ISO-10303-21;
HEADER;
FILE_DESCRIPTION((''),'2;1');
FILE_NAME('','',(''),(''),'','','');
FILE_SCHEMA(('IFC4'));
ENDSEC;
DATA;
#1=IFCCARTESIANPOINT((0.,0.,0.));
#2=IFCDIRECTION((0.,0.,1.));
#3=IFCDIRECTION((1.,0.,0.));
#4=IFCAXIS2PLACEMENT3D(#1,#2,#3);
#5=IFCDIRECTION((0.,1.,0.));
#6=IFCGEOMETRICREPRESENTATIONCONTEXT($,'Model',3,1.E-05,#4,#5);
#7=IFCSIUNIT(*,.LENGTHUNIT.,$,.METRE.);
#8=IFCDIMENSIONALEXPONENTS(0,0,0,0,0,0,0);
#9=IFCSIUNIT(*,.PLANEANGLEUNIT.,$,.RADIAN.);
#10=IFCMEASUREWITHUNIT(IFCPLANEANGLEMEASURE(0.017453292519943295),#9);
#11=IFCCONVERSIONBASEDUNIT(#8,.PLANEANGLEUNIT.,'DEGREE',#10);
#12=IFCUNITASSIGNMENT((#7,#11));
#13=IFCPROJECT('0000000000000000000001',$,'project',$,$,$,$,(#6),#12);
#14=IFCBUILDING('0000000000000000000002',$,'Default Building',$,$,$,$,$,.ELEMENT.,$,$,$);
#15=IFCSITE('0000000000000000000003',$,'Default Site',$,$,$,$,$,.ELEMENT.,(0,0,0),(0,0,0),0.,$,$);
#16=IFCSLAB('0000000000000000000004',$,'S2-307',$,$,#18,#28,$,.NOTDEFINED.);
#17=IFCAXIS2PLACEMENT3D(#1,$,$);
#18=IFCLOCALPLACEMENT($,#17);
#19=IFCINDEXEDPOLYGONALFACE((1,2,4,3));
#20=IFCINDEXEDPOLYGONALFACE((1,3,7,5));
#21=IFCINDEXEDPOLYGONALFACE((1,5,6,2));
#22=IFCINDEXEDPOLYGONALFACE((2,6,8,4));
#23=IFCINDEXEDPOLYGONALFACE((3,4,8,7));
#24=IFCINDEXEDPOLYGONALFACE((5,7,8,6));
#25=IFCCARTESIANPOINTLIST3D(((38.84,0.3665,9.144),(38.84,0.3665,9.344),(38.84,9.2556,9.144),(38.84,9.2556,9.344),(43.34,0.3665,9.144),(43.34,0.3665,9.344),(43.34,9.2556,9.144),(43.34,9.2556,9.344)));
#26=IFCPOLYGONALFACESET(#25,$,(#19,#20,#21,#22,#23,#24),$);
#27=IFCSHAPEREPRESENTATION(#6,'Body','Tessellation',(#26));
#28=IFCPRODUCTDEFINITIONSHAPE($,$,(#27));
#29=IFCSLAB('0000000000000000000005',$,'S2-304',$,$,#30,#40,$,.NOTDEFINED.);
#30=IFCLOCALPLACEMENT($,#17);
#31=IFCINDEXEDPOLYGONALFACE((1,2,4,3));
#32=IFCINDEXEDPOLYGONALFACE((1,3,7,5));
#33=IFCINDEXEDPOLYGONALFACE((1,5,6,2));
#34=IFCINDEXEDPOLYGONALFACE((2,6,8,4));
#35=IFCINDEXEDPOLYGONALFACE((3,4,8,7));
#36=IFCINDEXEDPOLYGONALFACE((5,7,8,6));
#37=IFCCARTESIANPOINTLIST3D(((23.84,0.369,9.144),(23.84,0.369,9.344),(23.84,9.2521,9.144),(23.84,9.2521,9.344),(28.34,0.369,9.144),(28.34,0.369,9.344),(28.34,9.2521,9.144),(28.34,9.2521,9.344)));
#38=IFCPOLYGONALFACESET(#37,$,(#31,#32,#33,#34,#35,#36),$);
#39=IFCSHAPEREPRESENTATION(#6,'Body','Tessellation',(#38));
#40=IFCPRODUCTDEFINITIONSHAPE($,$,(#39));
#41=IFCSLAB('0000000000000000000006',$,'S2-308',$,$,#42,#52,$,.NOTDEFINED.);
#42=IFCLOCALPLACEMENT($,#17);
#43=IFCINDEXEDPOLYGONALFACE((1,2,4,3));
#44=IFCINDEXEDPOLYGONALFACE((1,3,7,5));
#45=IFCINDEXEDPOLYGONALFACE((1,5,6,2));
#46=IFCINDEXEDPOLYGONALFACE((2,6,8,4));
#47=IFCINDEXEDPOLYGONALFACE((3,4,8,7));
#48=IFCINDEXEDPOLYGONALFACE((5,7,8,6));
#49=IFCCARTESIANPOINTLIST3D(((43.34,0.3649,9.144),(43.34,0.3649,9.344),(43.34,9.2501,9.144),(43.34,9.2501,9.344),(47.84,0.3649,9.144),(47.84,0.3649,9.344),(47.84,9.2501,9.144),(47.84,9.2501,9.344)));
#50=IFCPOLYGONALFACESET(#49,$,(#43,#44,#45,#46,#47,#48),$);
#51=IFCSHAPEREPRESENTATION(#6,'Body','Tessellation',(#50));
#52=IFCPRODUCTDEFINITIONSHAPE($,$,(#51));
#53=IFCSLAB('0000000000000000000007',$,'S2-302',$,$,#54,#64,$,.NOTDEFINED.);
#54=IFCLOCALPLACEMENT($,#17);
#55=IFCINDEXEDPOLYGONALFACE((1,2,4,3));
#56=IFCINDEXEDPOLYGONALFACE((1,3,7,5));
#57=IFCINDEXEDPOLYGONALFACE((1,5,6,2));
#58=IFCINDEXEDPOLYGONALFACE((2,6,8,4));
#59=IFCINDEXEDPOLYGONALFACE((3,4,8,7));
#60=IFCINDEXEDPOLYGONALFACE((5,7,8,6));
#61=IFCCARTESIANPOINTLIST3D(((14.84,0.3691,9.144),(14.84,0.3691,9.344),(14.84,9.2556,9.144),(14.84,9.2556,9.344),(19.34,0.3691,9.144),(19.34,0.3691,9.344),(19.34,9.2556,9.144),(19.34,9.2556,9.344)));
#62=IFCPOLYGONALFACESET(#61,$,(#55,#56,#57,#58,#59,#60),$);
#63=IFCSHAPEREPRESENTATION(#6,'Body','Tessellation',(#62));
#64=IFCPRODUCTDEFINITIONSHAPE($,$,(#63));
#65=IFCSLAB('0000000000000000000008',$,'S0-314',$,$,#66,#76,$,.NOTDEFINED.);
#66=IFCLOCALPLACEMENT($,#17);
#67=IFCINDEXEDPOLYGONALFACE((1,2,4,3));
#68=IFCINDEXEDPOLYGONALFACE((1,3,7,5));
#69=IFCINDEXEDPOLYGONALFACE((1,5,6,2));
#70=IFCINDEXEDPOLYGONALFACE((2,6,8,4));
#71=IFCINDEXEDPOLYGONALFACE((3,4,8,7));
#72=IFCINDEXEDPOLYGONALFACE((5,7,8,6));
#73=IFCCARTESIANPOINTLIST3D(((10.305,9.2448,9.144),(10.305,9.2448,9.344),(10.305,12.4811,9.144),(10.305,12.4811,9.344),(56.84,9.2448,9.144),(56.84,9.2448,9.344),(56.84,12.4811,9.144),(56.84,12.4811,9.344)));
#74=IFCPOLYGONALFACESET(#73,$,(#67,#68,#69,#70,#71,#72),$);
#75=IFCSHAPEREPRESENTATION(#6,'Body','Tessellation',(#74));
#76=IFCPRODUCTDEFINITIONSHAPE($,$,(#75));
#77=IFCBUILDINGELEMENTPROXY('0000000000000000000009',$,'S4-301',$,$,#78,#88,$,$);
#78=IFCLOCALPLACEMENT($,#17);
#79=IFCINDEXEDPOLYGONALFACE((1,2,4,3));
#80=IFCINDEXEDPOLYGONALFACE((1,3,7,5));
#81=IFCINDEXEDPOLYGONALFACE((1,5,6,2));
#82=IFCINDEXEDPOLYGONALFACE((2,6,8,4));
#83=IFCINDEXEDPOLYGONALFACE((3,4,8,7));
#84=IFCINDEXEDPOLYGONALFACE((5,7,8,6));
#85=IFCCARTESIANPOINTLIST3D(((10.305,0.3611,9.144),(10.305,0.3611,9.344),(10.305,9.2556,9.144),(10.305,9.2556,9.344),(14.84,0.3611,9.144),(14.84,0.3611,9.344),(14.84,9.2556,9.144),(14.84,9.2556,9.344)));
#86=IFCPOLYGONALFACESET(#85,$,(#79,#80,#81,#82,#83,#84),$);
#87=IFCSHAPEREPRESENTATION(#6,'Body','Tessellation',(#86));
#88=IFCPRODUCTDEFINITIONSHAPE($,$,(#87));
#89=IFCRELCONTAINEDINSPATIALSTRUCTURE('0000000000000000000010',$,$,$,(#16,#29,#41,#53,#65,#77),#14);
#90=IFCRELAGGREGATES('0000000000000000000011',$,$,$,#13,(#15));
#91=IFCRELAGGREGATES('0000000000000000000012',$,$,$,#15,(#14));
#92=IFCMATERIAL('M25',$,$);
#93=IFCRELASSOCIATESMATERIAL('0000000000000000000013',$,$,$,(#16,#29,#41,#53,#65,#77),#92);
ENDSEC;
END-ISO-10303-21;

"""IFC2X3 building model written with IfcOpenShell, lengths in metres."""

from ifc_helpers import new_model, entity, si_unit, converted_unit, direction, frame, frame_2d, origin_with_axes, place, context, project, spatial, rectangle, extrude, material, element, save


model = new_model("IFC2X3")

# Units and contexts
model_context = context("Model", 3, precision=1e-05, world=origin_with_axes(), true_north=direction((0.0, 1.0, 0.0)))
ifc_project = project(units=[si_unit("LENGTHUNIT", "METRE"), converted_unit("PLANEANGLEUNIT", "DEGREE", entity("IfcPlaneAngleMeasure", 0.017453292519943295), si_unit("PLANEANGLEUNIT", "RADIAN"), dimensions=[0, 0, 0, 0, 0, 0, 0])], contexts=[model_context])

# Site, building
site = spatial("IfcSite", under=ifc_project, Name="Default Site", CompositionType="ELEMENT", RefLatitude=(0, 0, 0), RefLongitude=(0, 0, 0), RefElevation=0.0)
building = spatial("IfcBuilding", under=site, Name="Default Building", CompositionType="ELEMENT")

# Shared definitions
ifc_material = material(Name="M25")
placement = place(None, origin_with_axes())

# Slabs
element("IfcSlab", 1, at=placement, inside=building, material=ifc_material, Name="S2-307", PredefinedType="NOTDEFINED", context=model_context, shape_type="SweptSolid", body=[
    extrude(rectangle(XDim=4.5, YDim=8.8891, at=frame_2d((0.0, 0.0), x_axis=(1.0, 0.0, 0.0))), frame((41.09, 4.811, 9.144), z_axis=(0.0, 0.0, 1.0), x_axis=(1.0, 0.0, 0.0)), (0.0, 0.0, 1.0), 0.2),
])
element("IfcSlab", 2, at=placement, inside=building, material=ifc_material, Name="S2-304", PredefinedType="NOTDEFINED", context=model_context, shape_type="SweptSolid", body=[
    extrude(rectangle(XDim=4.5, YDim=8.8831, at=frame_2d((0.0, 0.0), x_axis=(1.0, 0.0, 0.0))), frame((26.09, 4.8106, 9.144), z_axis=(0.0, 0.0, 1.0), x_axis=(1.0, 0.0, 0.0)), (0.0, 0.0, 1.0), 0.2),
])
element("IfcSlab", 3, at=placement, inside=building, material=ifc_material, Name="S2-308", PredefinedType="NOTDEFINED", context=model_context, shape_type="SweptSolid", body=[
    extrude(rectangle(XDim=4.5, YDim=8.8852, at=frame_2d((0.0, 0.0), x_axis=(1.0, 0.0, 0.0))), frame((45.59, 4.8075, 9.144), z_axis=(0.0, 0.0, 1.0), x_axis=(1.0, 0.0, 0.0)), (0.0, 0.0, 1.0), 0.2),
])
element("IfcSlab", 4, at=placement, inside=building, material=ifc_material, Name="S2-302", PredefinedType="NOTDEFINED", context=model_context, shape_type="SweptSolid", body=[
    extrude(rectangle(XDim=4.5, YDim=8.8865, at=frame_2d((0.0, 0.0), x_axis=(1.0, 0.0, 0.0))), frame((17.09, 4.8123, 9.144), z_axis=(0.0, 0.0, 1.0), x_axis=(1.0, 0.0, 0.0)), (0.0, 0.0, 1.0), 0.2),
])
element("IfcSlab", 5, at=placement, inside=building, material=ifc_material, Name="S0-314", PredefinedType="NOTDEFINED", context=model_context, shape_type="SweptSolid", body=[
    extrude(rectangle(XDim=46.535, YDim=3.2363, at=frame_2d((0.0, 0.0), x_axis=(1.0, 0.0, 0.0))), frame((33.5725, 10.863, 9.144), z_axis=(0.0, 0.0, 1.0), x_axis=(1.0, 0.0, 0.0)), (0.0, 0.0, 1.0), 0.2),
])

# Building element proxy
element("IfcBuildingElementProxy", 6, at=placement, inside=building, material=ifc_material, Name="S4-301", context=model_context, shape_type="SweptSolid", body=[
    extrude(rectangle(XDim=4.535, YDim=8.8945, at=frame_2d((0.0, 0.0), x_axis=(1.0, 0.0, 0.0))), frame((12.5725, 4.8083, 9.144), z_axis=(0.0, 0.0, 1.0), x_axis=(1.0, 0.0, 0.0)), (0.0, 0.0, 1.0), 0.2),
])

save(model, "model.ifc")
